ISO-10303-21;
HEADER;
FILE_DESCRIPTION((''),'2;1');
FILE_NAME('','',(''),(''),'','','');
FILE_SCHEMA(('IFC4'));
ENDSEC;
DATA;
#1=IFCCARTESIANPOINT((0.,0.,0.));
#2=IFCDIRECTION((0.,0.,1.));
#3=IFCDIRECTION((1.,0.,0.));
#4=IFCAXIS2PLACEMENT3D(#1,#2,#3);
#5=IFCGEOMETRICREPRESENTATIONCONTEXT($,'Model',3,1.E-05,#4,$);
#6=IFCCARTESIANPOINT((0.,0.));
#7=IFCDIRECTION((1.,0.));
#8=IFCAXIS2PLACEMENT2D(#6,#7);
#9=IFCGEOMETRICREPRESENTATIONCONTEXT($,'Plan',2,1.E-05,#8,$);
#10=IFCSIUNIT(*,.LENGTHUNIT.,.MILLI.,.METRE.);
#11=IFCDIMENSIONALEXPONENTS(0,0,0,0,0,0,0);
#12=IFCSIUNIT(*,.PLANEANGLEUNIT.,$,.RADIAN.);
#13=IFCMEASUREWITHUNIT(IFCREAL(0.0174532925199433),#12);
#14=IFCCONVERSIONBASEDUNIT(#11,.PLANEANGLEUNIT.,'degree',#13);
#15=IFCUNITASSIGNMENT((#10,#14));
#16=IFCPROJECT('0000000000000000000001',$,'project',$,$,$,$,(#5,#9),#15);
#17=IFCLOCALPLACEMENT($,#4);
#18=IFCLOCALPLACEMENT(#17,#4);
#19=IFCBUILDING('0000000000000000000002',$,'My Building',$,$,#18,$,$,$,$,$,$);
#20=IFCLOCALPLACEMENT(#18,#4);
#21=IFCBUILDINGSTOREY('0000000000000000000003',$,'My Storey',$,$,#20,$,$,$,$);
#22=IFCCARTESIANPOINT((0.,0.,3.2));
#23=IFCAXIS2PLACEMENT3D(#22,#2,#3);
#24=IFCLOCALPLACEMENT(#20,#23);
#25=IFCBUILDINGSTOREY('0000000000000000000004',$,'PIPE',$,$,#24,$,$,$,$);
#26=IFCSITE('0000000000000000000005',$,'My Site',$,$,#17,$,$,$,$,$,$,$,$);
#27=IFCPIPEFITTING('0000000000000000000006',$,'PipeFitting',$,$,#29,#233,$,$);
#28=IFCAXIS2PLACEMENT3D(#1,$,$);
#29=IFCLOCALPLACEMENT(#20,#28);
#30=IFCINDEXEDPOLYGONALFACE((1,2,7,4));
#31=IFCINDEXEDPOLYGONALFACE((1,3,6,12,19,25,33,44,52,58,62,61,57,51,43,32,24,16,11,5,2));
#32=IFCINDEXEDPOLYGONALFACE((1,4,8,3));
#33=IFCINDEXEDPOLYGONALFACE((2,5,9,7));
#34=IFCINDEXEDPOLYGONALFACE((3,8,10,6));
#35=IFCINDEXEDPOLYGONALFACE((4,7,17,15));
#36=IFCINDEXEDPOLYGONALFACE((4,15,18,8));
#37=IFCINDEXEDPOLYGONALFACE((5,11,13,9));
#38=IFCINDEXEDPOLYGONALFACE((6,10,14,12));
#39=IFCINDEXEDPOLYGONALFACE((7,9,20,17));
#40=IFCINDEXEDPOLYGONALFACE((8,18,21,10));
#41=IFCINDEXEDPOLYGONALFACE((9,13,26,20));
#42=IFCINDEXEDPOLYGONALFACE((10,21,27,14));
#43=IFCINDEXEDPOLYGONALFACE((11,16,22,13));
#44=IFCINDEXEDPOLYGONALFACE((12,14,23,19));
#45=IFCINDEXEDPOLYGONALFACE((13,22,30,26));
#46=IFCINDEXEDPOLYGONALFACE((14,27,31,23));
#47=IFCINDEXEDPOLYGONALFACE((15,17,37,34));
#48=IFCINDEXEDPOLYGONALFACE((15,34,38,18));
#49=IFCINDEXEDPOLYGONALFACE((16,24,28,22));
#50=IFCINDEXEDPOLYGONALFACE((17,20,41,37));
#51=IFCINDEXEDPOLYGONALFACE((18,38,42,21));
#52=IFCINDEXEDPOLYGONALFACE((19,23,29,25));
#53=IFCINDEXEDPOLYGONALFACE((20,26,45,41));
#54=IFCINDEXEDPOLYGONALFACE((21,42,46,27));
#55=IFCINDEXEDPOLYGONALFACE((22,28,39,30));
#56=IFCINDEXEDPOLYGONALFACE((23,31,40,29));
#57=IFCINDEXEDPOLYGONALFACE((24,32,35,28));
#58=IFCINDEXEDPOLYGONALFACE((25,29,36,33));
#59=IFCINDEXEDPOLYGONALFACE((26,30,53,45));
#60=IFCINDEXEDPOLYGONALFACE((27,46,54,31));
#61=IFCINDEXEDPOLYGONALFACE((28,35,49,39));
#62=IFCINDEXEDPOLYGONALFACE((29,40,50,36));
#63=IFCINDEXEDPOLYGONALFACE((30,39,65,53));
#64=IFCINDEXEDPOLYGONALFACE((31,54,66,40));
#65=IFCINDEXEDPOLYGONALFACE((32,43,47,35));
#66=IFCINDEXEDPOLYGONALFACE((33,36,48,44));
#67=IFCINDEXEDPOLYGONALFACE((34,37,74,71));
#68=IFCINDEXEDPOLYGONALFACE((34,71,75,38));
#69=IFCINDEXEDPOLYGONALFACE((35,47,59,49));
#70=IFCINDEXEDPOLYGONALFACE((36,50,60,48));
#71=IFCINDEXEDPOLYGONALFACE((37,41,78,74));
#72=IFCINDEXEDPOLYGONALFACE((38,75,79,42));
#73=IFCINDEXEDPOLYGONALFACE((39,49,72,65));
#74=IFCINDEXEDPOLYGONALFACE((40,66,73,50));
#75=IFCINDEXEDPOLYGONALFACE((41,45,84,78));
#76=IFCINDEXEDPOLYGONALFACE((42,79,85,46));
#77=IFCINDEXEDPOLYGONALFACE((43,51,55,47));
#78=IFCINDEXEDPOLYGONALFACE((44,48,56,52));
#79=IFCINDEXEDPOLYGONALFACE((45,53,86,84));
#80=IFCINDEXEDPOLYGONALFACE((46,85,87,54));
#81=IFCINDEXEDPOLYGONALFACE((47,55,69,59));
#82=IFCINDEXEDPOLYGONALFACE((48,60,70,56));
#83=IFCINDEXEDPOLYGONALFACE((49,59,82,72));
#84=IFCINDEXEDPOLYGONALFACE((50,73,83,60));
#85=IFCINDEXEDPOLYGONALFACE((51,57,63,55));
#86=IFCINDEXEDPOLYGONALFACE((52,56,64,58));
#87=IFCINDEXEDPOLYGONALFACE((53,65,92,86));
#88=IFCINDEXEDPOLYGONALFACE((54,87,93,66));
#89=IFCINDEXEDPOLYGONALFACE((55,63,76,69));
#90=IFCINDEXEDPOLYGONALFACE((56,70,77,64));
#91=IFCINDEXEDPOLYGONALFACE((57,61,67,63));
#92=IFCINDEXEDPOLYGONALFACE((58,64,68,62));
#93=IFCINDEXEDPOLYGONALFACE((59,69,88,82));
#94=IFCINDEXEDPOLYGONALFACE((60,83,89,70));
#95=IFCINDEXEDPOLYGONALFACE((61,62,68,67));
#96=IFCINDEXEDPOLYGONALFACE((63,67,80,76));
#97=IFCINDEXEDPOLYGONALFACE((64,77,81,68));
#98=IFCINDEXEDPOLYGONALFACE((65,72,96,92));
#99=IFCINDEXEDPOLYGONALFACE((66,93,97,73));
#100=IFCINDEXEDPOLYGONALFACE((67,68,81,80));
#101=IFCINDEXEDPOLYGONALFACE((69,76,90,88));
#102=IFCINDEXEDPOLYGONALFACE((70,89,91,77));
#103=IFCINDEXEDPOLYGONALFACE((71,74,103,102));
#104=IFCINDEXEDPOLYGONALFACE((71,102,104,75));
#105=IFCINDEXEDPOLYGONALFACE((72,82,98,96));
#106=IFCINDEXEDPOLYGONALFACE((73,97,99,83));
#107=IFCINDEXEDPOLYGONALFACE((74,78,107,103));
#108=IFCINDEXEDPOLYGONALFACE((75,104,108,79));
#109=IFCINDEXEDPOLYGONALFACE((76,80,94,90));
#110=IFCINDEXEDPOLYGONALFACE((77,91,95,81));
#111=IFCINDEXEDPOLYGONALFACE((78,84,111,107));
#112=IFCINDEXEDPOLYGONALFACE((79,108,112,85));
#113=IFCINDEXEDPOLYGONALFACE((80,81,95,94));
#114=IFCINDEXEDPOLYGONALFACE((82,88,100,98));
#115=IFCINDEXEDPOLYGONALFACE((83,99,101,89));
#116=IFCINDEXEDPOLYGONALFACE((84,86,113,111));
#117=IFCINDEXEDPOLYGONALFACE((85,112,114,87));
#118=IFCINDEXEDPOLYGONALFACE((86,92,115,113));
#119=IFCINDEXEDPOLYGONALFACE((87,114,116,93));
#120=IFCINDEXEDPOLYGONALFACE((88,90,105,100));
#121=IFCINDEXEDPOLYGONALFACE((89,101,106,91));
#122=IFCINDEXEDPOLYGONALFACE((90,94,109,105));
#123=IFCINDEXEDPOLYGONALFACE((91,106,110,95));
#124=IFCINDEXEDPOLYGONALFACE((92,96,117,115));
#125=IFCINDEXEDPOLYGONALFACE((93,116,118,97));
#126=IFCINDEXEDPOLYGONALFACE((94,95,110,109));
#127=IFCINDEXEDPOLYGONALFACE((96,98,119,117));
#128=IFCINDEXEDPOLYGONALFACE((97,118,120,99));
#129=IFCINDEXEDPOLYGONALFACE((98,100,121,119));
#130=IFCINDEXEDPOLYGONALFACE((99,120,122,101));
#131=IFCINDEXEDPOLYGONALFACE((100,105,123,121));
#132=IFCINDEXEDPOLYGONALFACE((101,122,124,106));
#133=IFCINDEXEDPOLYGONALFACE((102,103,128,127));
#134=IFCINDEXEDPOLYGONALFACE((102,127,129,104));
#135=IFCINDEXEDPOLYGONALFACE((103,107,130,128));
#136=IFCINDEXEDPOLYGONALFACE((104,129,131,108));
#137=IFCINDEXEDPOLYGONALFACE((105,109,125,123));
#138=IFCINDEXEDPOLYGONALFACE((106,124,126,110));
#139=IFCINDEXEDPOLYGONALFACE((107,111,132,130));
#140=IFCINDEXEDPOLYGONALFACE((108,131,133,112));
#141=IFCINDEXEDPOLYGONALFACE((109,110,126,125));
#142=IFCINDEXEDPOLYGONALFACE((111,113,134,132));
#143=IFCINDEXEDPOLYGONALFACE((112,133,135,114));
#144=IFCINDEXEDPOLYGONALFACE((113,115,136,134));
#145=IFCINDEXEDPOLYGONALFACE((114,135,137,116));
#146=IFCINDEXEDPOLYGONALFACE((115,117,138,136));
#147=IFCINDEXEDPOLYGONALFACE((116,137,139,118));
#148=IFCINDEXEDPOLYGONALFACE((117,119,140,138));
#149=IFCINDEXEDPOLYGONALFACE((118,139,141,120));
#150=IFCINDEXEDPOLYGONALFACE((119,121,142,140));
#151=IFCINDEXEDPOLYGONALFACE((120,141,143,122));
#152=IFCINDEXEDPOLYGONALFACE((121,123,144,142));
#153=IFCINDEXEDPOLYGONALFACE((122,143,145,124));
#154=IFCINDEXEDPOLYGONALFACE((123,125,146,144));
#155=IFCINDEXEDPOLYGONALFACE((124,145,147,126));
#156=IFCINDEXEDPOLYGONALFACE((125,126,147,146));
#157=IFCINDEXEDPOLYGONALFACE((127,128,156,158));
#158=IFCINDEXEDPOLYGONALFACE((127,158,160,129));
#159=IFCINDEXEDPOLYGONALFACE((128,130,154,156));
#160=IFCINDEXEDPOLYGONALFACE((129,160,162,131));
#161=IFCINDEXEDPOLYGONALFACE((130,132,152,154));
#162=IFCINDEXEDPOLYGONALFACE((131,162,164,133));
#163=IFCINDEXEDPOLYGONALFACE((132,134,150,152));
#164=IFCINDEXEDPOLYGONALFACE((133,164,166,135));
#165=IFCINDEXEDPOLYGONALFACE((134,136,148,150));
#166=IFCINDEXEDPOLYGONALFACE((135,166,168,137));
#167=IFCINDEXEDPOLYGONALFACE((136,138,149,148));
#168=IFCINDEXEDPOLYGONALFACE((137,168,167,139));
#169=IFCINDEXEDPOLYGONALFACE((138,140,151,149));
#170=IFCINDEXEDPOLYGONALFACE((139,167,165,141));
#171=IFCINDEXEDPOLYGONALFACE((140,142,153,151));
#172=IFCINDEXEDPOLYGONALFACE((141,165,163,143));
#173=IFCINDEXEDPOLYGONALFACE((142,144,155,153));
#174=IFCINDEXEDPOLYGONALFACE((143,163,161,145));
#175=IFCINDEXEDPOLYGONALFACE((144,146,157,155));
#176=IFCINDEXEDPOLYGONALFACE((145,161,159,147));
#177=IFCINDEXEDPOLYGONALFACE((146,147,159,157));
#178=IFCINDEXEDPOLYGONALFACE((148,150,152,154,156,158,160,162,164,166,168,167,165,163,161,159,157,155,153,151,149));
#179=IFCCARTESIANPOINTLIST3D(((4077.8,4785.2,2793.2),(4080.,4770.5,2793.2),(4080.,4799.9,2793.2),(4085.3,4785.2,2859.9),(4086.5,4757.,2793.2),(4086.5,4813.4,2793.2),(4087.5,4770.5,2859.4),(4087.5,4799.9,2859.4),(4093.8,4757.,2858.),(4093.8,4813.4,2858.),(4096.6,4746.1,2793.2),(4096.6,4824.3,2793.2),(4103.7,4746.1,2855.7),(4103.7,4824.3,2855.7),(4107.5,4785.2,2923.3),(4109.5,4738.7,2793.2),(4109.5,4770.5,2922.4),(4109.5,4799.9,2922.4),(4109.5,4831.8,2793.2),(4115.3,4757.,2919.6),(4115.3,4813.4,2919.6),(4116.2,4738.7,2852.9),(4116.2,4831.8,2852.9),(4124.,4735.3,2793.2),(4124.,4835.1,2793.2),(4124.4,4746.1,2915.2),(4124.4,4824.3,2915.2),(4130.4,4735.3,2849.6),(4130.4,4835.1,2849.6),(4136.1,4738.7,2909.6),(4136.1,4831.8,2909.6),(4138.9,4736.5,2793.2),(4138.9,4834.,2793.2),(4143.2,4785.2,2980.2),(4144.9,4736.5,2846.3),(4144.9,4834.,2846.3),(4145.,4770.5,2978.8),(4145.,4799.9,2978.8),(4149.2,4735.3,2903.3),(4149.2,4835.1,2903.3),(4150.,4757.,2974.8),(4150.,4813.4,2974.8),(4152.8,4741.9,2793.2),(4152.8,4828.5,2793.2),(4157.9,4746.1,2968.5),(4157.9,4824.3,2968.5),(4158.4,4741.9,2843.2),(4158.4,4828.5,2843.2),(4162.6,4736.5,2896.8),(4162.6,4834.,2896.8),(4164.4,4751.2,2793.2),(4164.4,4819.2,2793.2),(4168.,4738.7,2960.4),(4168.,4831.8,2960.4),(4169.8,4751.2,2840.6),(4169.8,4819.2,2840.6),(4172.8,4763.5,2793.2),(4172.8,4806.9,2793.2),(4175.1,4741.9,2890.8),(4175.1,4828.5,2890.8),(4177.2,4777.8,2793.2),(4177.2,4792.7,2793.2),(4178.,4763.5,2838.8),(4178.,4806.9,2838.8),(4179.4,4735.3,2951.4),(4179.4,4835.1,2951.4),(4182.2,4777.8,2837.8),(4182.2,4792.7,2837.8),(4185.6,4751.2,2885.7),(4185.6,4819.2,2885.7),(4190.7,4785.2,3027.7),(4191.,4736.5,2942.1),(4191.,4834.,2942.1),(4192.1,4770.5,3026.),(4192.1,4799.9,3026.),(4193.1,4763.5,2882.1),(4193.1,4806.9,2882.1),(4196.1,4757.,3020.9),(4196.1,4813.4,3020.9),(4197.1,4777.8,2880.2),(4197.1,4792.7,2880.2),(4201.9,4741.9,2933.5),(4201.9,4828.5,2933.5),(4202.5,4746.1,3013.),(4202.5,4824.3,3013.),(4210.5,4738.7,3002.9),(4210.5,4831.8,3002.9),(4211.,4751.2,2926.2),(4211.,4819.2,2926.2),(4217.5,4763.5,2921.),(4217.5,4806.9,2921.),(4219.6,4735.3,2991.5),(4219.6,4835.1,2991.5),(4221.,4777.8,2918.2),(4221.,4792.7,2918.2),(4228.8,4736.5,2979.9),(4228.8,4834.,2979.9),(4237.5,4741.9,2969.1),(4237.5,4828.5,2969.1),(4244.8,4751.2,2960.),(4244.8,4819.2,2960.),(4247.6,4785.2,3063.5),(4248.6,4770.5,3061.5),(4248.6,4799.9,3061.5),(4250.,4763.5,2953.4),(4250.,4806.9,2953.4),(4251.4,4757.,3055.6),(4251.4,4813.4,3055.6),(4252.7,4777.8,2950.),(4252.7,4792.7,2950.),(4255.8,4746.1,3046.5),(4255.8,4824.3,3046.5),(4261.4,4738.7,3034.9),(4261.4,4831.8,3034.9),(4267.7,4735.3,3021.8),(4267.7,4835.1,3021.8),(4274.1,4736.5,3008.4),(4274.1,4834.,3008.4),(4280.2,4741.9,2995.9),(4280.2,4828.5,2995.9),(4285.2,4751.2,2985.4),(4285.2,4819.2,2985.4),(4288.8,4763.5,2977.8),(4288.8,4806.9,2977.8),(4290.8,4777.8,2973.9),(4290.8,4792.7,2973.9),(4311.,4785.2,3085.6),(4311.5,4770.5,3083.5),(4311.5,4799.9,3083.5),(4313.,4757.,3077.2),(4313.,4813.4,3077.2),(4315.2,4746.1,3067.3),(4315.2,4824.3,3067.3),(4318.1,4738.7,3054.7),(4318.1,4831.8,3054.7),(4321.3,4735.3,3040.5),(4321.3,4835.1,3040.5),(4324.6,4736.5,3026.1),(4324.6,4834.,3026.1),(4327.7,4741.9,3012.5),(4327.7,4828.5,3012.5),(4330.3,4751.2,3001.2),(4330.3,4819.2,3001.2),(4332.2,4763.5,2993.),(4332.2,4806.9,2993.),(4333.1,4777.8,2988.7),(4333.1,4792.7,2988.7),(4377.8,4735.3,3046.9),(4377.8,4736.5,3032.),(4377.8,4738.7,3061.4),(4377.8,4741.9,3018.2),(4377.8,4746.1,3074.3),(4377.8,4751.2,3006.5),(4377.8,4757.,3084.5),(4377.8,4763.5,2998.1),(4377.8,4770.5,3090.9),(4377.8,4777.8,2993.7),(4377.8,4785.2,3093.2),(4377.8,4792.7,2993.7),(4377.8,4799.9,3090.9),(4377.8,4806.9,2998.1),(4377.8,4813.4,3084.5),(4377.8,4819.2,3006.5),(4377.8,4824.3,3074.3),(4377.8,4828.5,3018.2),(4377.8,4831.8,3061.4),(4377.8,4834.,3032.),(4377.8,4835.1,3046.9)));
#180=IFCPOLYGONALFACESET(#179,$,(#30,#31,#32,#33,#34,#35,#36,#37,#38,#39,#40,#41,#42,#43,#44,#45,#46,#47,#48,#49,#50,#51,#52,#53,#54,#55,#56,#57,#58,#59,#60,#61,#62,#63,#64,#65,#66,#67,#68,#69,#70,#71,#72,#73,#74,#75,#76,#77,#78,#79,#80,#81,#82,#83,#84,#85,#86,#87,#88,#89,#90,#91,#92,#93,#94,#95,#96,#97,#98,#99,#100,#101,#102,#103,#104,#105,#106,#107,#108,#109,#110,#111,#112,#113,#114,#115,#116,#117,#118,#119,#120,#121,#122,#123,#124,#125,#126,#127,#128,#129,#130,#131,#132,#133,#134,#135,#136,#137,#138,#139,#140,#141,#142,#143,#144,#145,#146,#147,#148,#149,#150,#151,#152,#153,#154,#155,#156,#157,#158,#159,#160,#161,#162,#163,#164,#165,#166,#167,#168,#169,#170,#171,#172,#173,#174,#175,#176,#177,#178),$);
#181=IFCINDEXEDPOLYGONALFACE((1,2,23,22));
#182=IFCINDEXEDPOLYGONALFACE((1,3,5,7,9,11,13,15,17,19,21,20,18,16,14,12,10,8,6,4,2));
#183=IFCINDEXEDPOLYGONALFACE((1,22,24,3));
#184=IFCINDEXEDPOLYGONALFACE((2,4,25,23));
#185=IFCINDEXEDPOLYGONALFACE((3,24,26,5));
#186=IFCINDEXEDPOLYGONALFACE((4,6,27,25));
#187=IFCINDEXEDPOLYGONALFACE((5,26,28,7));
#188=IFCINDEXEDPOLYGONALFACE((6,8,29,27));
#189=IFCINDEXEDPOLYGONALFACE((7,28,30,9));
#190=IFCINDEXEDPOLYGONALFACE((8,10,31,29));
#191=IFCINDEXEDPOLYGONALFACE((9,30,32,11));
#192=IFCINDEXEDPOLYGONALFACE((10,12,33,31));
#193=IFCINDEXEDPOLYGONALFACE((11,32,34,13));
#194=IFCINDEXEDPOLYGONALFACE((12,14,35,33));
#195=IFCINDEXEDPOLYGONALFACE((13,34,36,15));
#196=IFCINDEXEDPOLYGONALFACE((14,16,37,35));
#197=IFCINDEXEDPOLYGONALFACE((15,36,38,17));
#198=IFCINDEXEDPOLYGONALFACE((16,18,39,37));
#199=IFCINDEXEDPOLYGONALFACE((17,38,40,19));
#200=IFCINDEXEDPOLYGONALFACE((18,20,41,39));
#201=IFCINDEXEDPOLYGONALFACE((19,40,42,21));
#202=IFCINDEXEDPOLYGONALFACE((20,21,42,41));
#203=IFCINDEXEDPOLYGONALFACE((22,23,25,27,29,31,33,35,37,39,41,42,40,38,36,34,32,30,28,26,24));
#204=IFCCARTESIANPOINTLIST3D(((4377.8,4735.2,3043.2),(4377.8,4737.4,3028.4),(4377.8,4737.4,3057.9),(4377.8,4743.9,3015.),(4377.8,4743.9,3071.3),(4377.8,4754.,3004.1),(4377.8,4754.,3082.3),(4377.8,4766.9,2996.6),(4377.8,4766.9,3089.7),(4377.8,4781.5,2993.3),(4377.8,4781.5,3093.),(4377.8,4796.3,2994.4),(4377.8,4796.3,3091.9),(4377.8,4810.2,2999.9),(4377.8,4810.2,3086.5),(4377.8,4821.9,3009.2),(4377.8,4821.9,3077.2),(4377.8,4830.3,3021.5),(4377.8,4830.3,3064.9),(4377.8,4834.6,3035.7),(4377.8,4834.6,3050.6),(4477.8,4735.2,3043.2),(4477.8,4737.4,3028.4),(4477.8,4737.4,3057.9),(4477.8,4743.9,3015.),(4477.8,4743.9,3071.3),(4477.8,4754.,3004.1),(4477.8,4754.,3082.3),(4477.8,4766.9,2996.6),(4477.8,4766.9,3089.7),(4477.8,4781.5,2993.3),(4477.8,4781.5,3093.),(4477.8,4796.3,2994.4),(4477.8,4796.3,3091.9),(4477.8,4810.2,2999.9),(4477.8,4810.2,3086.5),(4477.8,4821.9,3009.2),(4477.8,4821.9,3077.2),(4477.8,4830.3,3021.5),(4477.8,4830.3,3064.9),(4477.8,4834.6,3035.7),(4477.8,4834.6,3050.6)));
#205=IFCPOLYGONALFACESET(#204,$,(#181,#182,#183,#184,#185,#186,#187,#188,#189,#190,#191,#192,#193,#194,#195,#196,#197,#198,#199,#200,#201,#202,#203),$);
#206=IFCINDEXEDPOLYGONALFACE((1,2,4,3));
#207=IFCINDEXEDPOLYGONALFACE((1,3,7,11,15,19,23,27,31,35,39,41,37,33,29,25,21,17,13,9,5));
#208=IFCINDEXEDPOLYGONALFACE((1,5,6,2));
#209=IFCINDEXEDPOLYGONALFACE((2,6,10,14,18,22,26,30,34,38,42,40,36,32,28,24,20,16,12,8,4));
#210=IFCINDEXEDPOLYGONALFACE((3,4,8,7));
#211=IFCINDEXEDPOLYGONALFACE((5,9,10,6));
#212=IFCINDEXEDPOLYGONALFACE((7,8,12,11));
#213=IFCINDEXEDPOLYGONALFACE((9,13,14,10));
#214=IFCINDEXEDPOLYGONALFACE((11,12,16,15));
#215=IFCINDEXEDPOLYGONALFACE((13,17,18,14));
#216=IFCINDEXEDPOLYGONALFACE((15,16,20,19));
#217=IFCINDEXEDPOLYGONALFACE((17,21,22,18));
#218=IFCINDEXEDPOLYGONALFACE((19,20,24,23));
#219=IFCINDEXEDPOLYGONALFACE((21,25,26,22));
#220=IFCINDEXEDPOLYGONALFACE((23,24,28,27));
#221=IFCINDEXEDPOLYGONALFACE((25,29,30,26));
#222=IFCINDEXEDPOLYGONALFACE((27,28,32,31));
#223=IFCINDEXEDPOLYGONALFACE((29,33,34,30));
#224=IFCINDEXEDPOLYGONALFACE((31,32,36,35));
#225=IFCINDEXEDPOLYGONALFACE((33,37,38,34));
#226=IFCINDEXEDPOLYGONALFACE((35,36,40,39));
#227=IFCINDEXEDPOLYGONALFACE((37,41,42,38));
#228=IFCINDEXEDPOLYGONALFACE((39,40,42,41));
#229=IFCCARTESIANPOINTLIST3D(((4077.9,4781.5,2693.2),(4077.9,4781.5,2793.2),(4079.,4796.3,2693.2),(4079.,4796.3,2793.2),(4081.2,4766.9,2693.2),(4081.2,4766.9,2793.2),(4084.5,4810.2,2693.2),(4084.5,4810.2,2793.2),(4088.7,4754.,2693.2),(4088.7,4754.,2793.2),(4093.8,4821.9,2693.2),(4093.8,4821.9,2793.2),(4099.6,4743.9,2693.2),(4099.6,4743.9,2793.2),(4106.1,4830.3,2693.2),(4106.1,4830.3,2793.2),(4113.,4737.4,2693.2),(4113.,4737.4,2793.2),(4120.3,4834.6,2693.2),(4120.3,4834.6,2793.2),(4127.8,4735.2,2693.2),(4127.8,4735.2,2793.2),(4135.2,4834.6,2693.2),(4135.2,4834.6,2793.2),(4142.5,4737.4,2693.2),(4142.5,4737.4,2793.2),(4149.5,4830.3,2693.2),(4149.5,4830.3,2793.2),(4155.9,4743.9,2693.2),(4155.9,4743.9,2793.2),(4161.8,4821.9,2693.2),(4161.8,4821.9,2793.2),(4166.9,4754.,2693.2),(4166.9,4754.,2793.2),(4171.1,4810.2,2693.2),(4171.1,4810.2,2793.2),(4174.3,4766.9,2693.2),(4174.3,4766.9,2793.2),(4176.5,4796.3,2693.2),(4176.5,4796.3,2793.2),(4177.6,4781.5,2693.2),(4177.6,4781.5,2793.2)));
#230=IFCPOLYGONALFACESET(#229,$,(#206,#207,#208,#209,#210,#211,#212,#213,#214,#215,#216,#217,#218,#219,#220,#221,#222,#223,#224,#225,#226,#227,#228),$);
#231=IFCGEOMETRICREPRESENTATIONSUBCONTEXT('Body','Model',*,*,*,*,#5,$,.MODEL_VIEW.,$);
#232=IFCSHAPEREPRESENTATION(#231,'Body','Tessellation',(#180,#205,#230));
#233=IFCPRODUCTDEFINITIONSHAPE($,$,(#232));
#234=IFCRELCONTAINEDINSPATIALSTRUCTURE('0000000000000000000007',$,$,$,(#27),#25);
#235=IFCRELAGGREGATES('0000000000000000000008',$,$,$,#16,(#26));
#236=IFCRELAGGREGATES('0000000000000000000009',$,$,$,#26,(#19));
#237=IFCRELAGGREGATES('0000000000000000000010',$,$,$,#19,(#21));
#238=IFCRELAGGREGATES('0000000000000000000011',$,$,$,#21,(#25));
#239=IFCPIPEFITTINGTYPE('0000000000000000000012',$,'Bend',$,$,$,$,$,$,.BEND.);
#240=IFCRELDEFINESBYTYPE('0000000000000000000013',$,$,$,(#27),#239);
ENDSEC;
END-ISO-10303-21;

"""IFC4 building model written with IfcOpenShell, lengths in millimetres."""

from ifc_helpers import new_model, entity, si_unit, converted_unit, frame, origin_with_axes, origin_2d_with_axis, place, context, subcontext, project, spatial, circle, extrude, source, transform, mapped, type_object, type_shapes, element, save


model = new_model("IFC4")

# Units and contexts
model_context = context("Model", 3, precision=1e-05, world=origin_with_axes())
plan_context = context("Plan", 2, precision=1e-05, world=origin_2d_with_axis())
body_context = subcontext(model_context, "Body", "Model", "MODEL_VIEW")
ifc_project = project(units=[si_unit("LENGTHUNIT", "METRE", prefix="MILLI"), converted_unit("PLANEANGLEUNIT", "degree", entity("IfcReal", 0.0174532925199433), si_unit("PLANEANGLEUNIT", "RADIAN"), dimensions=[0, 0, 0, 0, 0, 0, 0])], contexts=[model_context, plan_context])

# Site, building, storeys
site_placement = place(None, origin_with_axes())
site = spatial("IfcSite", under=ifc_project, at=site_placement, Name="My Site")
building_placement = place(site_placement, origin_with_axes())
building = spatial("IfcBuilding", under=site, at=building_placement, Name="My Building")
storey_1_placement = place(building_placement, origin_with_axes())
storey_1 = spatial("IfcBuildingStorey", under=building, at=storey_1_placement, Name="My Storey")
storey_2_placement = place(storey_1_placement, frame((0.0, 0.0, 3.2), z_axis=(0.0, 0.0, 1.0), x_axis=(1.0, 0.0, 0.0)))
storey_2 = spatial("IfcBuildingStorey", under=storey_1, at=storey_2_placement, Name="PIPE")

# Pipe fitting
pipe_fitting_type = type_object("IfcPipeFittingType", Name="Bend", PredefinedType="BEND")
shared_shape = source(origin_with_axes(), body_context, "Body", "SolidModel", [
    entity("IfcSweptDiskSolid", entity("IfcIndexedPolyCurve", entity("IfcCartesianPointList3D", [[0.0, 0.0, 100.0], [0.0, -73.2, 276.8], [0.0, -250.0, 350.0]]), [entity("IfcArcIndex", [1, 2, 3])]), 50.0),
    extrude(circle(Radius=50.0), origin_with_axes(), (0.0, 0.0, 1.0), 100.0),
    extrude(circle(Radius=50.0), frame((0.0, -250.0, 350.0), z_axis=(0.0, -1.0, 0.0), x_axis=(1.0, 0.0, 0.0)), (0.0, 0.0, 1.0), 100.0),
])
type_shapes(pipe_fitting_type, [shared_shape])
for number, where, z_axis, x_axis, name in (
    (1, (4477.8, 4785.2, 3040.0), (-1.0, 0.0, 0.0), (0.0, -1.0, 0.0), "PipeFitting"),
):
    element("IfcPipeFitting", number, at=place(storey_2_placement, frame(where, z_axis=z_axis, x_axis=x_axis)), inside=storey_2, type_object=pipe_fitting_type, Name=name, context=body_context, shape_type="MappedRepresentation", body=[
        mapped(shared_shape, transform((0.0, 0.0, 0.0), x_axis=(1.0, 0.0, 0.0), y_axis=(0.0, 1.0, 0.0), z_axis=(0.0, 0.0, 1.0), scale=1.0)),
    ])

save(model, "model.ifc")
